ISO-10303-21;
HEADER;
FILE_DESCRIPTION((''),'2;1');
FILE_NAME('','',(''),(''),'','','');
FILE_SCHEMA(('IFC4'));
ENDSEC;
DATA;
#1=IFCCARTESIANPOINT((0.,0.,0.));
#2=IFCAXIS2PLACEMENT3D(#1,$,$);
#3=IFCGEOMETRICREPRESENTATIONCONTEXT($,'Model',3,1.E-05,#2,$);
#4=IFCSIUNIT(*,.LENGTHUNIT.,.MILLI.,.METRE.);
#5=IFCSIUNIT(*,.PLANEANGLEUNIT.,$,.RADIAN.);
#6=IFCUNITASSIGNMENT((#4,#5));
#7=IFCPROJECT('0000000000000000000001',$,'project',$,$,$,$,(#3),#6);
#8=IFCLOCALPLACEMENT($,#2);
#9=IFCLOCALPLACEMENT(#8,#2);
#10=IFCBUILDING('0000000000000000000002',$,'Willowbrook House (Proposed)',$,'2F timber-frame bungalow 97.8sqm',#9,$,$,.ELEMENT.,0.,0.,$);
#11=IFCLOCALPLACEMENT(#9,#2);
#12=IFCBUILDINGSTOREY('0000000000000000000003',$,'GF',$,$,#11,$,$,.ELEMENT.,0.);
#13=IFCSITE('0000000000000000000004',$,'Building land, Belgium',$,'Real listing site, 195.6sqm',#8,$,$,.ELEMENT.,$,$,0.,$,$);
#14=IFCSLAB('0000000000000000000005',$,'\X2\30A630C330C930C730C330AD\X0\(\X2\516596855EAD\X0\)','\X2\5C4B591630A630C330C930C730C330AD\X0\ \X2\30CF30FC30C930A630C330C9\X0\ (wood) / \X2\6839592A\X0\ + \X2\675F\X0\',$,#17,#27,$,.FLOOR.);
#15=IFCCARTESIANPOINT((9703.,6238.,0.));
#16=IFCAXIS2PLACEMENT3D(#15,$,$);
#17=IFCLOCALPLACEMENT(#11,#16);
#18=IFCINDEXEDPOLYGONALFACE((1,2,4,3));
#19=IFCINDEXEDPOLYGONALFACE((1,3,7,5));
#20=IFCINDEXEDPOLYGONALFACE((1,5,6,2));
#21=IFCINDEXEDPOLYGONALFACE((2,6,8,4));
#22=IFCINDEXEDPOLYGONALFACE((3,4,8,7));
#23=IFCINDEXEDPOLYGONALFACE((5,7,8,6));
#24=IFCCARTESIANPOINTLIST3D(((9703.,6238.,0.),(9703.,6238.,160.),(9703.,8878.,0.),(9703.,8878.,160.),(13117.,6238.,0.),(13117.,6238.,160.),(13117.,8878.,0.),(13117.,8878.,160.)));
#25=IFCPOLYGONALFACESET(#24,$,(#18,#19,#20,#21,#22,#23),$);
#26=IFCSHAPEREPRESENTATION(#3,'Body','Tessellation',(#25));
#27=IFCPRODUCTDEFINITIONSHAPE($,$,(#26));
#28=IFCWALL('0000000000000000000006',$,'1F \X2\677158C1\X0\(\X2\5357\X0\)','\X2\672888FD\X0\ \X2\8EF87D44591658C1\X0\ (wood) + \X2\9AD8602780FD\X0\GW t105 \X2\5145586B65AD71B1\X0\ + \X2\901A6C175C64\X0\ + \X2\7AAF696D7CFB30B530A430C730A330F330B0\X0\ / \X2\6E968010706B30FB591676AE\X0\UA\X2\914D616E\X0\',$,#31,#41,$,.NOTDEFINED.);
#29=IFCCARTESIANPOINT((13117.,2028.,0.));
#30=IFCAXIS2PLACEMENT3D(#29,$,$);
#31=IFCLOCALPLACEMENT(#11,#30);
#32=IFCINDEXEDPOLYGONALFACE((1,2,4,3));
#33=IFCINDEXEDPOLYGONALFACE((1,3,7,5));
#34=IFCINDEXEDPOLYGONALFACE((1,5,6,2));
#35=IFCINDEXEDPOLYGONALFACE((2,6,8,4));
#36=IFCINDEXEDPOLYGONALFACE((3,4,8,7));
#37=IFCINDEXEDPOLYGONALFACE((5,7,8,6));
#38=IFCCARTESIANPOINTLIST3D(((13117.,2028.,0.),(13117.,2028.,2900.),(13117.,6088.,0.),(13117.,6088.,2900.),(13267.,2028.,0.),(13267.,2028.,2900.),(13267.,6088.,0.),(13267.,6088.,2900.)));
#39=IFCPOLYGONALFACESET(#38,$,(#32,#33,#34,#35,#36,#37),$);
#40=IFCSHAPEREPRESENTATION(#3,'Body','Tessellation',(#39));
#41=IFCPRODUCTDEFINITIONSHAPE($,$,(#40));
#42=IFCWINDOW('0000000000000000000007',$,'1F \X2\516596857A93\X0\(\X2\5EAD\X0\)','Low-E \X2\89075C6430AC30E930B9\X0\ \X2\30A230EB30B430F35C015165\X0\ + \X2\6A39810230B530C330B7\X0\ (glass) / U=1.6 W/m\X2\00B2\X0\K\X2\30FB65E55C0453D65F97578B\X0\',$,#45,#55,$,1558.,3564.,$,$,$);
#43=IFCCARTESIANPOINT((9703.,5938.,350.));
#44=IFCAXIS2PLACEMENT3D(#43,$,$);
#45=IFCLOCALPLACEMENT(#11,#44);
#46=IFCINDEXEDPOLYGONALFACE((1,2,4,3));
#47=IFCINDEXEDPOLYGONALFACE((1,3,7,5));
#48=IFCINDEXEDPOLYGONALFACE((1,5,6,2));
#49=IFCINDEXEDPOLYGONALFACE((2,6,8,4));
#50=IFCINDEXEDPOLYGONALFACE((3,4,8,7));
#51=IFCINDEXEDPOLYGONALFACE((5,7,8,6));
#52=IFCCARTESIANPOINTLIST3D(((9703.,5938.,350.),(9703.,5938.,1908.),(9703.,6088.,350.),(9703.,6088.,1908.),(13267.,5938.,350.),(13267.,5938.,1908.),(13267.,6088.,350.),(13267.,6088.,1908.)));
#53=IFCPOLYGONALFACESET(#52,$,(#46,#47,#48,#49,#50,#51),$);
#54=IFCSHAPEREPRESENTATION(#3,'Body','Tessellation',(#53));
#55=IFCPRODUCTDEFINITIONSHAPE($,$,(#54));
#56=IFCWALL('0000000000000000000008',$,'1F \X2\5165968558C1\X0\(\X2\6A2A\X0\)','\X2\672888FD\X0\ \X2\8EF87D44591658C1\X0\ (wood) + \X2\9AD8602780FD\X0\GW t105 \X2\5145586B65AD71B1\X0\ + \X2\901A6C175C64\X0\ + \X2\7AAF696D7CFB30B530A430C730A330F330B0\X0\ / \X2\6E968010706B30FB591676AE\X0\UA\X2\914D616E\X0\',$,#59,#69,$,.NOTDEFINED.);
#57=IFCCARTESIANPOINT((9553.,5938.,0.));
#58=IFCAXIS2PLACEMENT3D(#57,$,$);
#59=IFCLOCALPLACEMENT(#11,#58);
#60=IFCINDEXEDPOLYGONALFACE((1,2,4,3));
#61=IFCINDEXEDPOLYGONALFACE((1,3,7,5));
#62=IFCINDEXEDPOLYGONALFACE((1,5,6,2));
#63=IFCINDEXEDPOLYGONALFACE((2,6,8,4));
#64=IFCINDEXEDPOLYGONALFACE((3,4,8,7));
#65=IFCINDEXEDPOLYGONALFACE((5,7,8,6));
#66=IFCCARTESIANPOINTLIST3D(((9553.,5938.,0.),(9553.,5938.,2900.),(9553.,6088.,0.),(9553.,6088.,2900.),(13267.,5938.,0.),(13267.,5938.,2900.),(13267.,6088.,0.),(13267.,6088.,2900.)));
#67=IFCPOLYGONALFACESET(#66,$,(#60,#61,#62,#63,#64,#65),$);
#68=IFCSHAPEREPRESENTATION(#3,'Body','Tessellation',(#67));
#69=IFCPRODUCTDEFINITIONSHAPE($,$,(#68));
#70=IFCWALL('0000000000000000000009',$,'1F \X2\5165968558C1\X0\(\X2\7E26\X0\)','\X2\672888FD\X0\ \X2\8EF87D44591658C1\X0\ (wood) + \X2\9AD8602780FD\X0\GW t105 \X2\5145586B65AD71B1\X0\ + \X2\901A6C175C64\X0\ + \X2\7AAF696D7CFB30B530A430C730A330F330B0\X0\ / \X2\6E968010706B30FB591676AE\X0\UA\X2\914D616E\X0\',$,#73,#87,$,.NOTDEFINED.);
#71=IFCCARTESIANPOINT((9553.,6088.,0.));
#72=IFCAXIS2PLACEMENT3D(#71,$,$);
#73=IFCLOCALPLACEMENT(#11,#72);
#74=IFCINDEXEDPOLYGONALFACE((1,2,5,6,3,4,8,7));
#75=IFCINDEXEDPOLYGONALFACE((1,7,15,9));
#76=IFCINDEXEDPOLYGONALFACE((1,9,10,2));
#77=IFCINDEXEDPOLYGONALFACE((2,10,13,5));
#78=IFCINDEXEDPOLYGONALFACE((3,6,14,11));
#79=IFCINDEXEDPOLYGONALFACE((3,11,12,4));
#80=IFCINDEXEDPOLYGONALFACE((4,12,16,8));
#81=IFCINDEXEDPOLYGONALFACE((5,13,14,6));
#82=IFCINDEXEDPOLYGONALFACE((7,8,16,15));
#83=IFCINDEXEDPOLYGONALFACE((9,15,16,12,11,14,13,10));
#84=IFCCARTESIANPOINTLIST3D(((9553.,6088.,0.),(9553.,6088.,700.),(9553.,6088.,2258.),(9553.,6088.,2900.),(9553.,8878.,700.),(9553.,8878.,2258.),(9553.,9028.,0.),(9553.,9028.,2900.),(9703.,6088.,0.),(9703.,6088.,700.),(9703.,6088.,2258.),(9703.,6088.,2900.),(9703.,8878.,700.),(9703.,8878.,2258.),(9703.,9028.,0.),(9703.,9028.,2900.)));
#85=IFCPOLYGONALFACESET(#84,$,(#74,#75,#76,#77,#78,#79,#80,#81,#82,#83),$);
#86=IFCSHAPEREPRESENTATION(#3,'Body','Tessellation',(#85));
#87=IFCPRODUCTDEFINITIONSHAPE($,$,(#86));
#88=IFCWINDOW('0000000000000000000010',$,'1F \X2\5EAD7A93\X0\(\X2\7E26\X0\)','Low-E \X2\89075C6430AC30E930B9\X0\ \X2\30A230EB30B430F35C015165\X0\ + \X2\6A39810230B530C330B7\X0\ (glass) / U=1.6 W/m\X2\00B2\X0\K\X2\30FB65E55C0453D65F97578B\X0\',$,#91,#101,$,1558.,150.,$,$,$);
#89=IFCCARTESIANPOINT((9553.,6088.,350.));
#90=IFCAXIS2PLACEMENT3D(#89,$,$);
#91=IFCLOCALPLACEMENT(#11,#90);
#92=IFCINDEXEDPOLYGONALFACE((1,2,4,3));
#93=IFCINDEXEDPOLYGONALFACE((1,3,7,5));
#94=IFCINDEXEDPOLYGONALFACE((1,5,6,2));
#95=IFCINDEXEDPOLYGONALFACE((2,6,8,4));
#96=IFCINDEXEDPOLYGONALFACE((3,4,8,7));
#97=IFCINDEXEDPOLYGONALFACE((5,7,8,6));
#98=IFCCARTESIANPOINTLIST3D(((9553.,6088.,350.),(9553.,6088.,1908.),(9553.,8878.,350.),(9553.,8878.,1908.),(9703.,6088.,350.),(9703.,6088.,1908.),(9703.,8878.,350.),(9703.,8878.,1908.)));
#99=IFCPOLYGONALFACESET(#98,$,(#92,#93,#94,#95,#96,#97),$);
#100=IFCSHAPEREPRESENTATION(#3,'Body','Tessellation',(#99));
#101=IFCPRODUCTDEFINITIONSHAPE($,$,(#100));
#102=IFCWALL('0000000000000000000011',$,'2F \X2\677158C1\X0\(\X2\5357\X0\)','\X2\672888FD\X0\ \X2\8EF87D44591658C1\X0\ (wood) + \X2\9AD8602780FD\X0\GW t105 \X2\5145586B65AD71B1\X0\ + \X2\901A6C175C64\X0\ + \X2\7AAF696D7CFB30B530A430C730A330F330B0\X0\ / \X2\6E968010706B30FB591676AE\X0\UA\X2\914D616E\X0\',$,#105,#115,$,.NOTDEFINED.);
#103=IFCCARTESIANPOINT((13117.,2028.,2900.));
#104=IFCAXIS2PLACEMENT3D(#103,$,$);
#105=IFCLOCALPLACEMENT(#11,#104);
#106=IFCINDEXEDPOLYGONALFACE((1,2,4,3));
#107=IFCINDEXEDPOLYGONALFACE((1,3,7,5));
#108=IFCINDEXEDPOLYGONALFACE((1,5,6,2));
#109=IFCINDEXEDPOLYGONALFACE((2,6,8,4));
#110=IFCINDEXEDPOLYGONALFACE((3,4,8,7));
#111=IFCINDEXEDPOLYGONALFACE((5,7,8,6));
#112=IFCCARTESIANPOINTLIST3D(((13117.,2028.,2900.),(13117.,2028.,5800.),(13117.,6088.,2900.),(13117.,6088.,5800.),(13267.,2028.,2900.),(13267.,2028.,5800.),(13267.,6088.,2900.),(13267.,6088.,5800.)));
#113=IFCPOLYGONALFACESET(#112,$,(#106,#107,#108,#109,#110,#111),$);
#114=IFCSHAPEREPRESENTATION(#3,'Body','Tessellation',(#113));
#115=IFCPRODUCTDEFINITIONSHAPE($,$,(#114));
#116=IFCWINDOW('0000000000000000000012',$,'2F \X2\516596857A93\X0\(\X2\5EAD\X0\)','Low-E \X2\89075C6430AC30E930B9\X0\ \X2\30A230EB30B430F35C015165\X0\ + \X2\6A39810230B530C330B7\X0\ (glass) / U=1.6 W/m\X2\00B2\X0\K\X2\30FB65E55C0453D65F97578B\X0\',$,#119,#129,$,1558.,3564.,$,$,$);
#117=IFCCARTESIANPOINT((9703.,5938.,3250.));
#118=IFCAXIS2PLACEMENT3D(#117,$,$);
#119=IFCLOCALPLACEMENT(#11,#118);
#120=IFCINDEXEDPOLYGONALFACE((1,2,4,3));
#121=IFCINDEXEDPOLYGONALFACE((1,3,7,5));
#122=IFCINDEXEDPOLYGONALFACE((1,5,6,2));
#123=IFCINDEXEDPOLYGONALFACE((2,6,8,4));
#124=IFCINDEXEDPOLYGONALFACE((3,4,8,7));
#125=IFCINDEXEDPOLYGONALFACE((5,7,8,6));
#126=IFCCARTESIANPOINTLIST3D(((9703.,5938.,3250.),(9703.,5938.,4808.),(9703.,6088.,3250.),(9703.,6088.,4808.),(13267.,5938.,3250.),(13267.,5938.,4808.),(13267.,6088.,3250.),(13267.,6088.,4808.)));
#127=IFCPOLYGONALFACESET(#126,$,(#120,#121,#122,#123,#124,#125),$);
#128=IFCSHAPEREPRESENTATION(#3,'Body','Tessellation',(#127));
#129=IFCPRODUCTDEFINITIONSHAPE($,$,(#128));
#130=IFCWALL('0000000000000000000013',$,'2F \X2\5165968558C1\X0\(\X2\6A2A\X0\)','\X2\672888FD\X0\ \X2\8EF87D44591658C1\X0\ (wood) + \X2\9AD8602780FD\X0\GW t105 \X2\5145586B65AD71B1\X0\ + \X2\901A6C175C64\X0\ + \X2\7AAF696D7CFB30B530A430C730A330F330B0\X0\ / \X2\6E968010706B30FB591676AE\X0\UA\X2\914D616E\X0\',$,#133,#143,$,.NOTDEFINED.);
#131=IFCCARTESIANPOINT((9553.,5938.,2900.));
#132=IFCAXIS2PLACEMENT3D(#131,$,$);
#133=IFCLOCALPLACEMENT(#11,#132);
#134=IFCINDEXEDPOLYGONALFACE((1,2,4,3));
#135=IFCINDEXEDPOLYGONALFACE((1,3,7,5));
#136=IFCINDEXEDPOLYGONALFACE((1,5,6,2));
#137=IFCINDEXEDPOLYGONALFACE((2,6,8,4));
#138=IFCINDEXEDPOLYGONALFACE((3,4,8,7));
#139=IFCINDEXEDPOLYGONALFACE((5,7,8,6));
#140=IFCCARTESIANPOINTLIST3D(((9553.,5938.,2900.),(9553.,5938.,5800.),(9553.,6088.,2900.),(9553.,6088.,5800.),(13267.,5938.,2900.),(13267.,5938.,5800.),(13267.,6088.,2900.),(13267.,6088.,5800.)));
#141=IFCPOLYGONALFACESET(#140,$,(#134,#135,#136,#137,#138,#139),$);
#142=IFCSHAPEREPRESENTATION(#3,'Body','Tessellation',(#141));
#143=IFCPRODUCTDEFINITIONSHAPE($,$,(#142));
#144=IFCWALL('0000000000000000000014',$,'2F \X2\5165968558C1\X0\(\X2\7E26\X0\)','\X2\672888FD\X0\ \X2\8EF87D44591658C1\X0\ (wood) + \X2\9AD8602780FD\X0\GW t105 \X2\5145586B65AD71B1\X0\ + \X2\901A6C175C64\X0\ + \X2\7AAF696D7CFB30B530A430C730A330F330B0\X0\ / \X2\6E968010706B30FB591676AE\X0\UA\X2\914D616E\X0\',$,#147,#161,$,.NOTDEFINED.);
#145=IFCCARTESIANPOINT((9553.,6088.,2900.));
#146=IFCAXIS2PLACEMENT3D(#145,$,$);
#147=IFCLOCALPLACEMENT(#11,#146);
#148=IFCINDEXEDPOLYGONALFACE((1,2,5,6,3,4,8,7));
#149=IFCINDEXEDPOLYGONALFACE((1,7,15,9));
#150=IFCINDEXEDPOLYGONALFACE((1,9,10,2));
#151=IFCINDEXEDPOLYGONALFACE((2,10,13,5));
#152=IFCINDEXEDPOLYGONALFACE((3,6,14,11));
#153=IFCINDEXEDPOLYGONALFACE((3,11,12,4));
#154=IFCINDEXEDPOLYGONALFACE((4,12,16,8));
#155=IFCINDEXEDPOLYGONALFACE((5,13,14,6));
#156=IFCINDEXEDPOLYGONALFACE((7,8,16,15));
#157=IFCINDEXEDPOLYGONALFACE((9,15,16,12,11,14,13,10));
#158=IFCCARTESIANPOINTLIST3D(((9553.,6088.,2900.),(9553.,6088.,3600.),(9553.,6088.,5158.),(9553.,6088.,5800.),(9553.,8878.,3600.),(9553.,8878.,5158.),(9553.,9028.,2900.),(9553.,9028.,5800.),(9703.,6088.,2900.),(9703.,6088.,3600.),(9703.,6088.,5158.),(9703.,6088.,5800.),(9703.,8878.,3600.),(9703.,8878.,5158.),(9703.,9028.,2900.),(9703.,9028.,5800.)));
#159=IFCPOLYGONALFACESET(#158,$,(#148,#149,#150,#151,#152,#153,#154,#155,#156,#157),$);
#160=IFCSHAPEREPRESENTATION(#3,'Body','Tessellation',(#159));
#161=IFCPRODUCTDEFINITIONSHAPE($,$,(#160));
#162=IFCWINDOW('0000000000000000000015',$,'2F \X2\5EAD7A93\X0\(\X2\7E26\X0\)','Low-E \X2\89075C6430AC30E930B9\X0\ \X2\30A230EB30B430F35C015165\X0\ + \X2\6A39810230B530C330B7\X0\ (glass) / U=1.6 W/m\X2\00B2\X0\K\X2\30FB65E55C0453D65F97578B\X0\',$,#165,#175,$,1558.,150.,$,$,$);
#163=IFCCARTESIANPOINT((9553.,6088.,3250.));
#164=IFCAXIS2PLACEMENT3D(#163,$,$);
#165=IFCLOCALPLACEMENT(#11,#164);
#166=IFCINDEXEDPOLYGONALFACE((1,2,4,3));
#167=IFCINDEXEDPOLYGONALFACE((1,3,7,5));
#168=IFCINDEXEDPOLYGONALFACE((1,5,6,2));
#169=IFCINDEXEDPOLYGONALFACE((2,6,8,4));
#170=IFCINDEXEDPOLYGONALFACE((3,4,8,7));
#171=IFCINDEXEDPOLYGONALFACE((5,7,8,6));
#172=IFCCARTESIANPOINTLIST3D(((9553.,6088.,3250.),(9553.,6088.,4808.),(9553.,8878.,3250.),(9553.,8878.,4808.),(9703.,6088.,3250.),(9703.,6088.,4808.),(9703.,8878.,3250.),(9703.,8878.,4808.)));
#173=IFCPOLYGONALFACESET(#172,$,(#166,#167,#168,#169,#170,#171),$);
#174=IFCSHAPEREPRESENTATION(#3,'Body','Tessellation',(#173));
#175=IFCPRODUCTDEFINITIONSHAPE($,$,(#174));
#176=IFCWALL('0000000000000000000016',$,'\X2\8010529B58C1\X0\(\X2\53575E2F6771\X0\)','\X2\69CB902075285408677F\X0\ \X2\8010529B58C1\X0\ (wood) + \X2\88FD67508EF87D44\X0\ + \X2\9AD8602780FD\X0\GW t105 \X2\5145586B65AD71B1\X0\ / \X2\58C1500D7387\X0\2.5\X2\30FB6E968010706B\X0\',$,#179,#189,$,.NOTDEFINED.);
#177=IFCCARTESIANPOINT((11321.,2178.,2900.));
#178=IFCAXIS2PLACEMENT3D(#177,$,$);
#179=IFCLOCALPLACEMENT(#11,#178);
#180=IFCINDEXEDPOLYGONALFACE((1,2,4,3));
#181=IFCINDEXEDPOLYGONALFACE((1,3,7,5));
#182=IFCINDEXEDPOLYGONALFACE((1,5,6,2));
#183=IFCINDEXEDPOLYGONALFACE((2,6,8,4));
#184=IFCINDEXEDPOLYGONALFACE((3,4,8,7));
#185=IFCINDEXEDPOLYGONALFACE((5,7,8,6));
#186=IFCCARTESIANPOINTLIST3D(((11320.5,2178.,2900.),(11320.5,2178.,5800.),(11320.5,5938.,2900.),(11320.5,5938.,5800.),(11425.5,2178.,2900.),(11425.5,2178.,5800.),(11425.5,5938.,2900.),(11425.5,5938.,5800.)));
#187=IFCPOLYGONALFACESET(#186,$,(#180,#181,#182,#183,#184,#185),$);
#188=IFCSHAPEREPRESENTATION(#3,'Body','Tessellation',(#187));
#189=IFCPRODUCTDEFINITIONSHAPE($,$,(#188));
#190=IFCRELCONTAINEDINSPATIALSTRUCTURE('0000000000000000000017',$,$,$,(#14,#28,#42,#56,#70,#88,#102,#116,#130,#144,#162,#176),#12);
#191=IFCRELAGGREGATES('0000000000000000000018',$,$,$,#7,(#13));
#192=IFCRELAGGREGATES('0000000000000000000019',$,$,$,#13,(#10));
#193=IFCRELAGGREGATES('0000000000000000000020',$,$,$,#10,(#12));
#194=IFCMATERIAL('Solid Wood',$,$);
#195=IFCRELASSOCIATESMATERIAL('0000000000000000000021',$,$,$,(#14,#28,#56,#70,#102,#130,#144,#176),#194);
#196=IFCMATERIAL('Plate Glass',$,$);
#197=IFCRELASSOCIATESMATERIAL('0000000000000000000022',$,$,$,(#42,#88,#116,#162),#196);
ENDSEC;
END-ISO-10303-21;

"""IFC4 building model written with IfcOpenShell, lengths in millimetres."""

from ifc_helpers import new_model, si_unit, frame, frame_2d, origin, place, context, project, spatial, rectangle, extrude, material, element, fill, save


model = new_model("IFC4")

# Units and contexts
model_context = context("Model", 3, precision=1e-05, world=origin())
ifc_project = project(units=[si_unit("LENGTHUNIT", "METRE", prefix="MILLI"), si_unit("PLANEANGLEUNIT", "RADIAN")], contexts=[model_context])

# Site, building, storey
site_placement = place(None, origin())
site = spatial("IfcSite", under=ifc_project, at=site_placement, Name="Building land, Belgium", ObjectType="Real listing site, 195.6sqm", CompositionType="ELEMENT", RefElevation=0.0)
building_placement = place(site_placement, origin())
building = spatial("IfcBuilding", under=site, at=building_placement, Name="Willowbrook House (Proposed)", ObjectType="2F timber-frame bungalow 97.8sqm", CompositionType="ELEMENT", ElevationOfRefHeight=0.0, ElevationOfTerrain=0.0)
storey_placement = place(building_placement, origin())
storey = spatial("IfcBuildingStorey", under=building, at=storey_placement, Name="GF", CompositionType="ELEMENT", Elevation=0.0)

# Slab
ifc_material_1 = material(Name="Solid Wood")
slab_placement = place(storey_placement, frame((9703.0, 6238.0, 0.0)))
element("IfcSlab", 1, at=slab_placement, inside=storey, material=ifc_material_1, Name="ウッドデッキ(入隅庭)", Description="屋外ウッドデッキ ハードウッド (wood) / 根太 + 束", PredefinedType="FLOOR", context=model_context, shape_type="SweptSolid", body=[
    extrude(rectangle(XDim=3414.0, YDim=2640.0, at=frame_2d((1707.0, 1320.0))), frame((9703.0, 6238.0, 0.0)), (0.0, 0.0, 1.0), 160.0),
])

# Wall, opening, window
wall_1_placement = place(storey_placement, frame((13117.0, 2028.0, 0.0)))
wall_1 = element("IfcWall", 2, at=wall_1_placement, inside=storey, material=ifc_material_1, Name="1F 東壁(南)", Description="木製 軸組外壁 (wood) + 高性能GW t105 充填断熱 + 通気層 + 窯業系サイディング / 準耐火・外皮UA配慮", PredefinedType="NOTDEFINED", context=model_context, shape_type="SweptSolid", body=[
    extrude(rectangle(XDim=150.0, YDim=4060.0, at=frame_2d((75.0, 2030.0))), frame((13117.0, 2028.0, 0.0)), (0.0, 0.0, 1.0), 2900.0),
])
opening_1_placement = place(storey_placement, frame((9703.0, 5938.0, 350.0)))
opening_1 = element("IfcOpeningElement", 3, at=opening_1_placement, cuts=wall_1, PredefinedType="NOTDEFINED", context=model_context, shape_type="SweptSolid", body=[
    extrude(rectangle(XDim=3564.0, YDim=150.0, at=frame_2d((1782.0, 75.0))), frame((9703.0, 5938.0, 350.0)), (0.0, 0.0, 1.0), 1558.0),
])
ifc_material_2 = material(Name="Plate Glass")
window_1_placement = place(storey_placement, frame((9703.0, 5938.0, 350.0)))
window_1 = element("IfcWindow", 4, at=window_1_placement, inside=storey, material=ifc_material_2, Name="1F 入隅窓(庭)", Description="Low-E 複層ガラス アルゴン封入 + 樹脂サッシ (glass) / U=1.6 W/m²K・日射取得型", OverallHeight=1558.0, OverallWidth=3564.0, context=model_context, shape_type="SweptSolid", body=[
    extrude(rectangle(XDim=3564.0, YDim=150.0, at=frame_2d((1782.0, 75.0))), frame((9703.0, 5938.0, 350.0)), (0.0, 0.0, 1.0), 1558.0),
])
fill(opening_1, window_1)

# Wall
wall_2_placement = place(storey_placement, frame((9553.0, 5938.0, 0.0)))
element("IfcWall", 5, at=wall_2_placement, inside=storey, material=ifc_material_1, Name="1F 入隅壁(横)", Description="木製 軸組外壁 (wood) + 高性能GW t105 充填断熱 + 通気層 + 窯業系サイディング / 準耐火・外皮UA配慮", PredefinedType="NOTDEFINED", context=model_context, shape_type="SweptSolid", body=[
    extrude(rectangle(XDim=3714.0, YDim=150.0, at=frame_2d((1857.0, 75.0))), frame((9553.0, 5938.0, 0.0)), (0.0, 0.0, 1.0), 2900.0),
])

# Wall, opening, window
wall_3_placement = place(storey_placement, frame((9553.0, 6088.0, 0.0)))
wall_3 = element("IfcWall", 6, at=wall_3_placement, inside=storey, material=ifc_material_1, Name="1F 入隅壁(縦)", Description="木製 軸組外壁 (wood) + 高性能GW t105 充填断熱 + 通気層 + 窯業系サイディング / 準耐火・外皮UA配慮", PredefinedType="NOTDEFINED", context=model_context, shape_type="SweptSolid", body=[
    extrude(rectangle(XDim=150.0, YDim=2940.0, at=frame_2d((75.0, 1470.0))), frame((9553.0, 6088.0, 0.0)), (0.0, 0.0, 1.0), 2900.0),
])
opening_2_placement = place(storey_placement, frame((9553.0, 6088.0, 350.0)))
opening_2 = element("IfcOpeningElement", 7, at=opening_2_placement, cuts=wall_3, PredefinedType="NOTDEFINED", context=model_context, shape_type="SweptSolid", body=[
    extrude(rectangle(XDim=150.0, YDim=2790.0, at=frame_2d((75.0, 1395.0))), frame((9553.0, 6088.0, 350.0)), (0.0, 0.0, 1.0), 1558.0),
])
window_2_placement = place(storey_placement, frame((9553.0, 6088.0, 350.0)))
window_2 = element("IfcWindow", 8, at=window_2_placement, inside=storey, material=ifc_material_2, Name="1F 庭窓(縦)", Description="Low-E 複層ガラス アルゴン封入 + 樹脂サッシ (glass) / U=1.6 W/m²K・日射取得型", OverallHeight=1558.0, OverallWidth=150.0, context=model_context, shape_type="SweptSolid", body=[
    extrude(rectangle(XDim=150.0, YDim=2790.0, at=frame_2d((75.0, 1395.0))), frame((9553.0, 6088.0, 350.0)), (0.0, 0.0, 1.0), 1558.0),
])
fill(opening_2, window_2)

# Wall, opening, window
wall_4_placement = place(storey_placement, frame((13117.0, 2028.0, 2900.0)))
wall_4 = element("IfcWall", 9, at=wall_4_placement, inside=storey, material=ifc_material_1, Name="2F 東壁(南)", Description="木製 軸組外壁 (wood) + 高性能GW t105 充填断熱 + 通気層 + 窯業系サイディング / 準耐火・外皮UA配慮", PredefinedType="NOTDEFINED", context=model_context, shape_type="SweptSolid", body=[
    extrude(rectangle(XDim=150.0, YDim=4060.0, at=frame_2d((75.0, 2030.0))), frame((13117.0, 2028.0, 2900.0)), (0.0, 0.0, 1.0), 2900.0),
])
opening_3_placement = place(storey_placement, frame((9703.0, 5938.0, 3250.0)))
opening_3 = element("IfcOpeningElement", 10, at=opening_3_placement, cuts=wall_4, PredefinedType="NOTDEFINED", context=model_context, shape_type="SweptSolid", body=[
    extrude(rectangle(XDim=3564.0, YDim=150.0, at=frame_2d((1782.0, 75.0))), frame((9703.0, 5938.0, 3250.0)), (0.0, 0.0, 1.0), 1558.0),
])
window_3_placement = place(storey_placement, frame((9703.0, 5938.0, 3250.0)))
window_3 = element("IfcWindow", 11, at=window_3_placement, inside=storey, material=ifc_material_2, Name="2F 入隅窓(庭)", Description="Low-E 複層ガラス アルゴン封入 + 樹脂サッシ (glass) / U=1.6 W/m²K・日射取得型", OverallHeight=1558.0, OverallWidth=3564.0, context=model_context, shape_type="SweptSolid", body=[
    extrude(rectangle(XDim=3564.0, YDim=150.0, at=frame_2d((1782.0, 75.0))), frame((9703.0, 5938.0, 3250.0)), (0.0, 0.0, 1.0), 1558.0),
])
fill(opening_3, window_3)

# Wall
wall_5_placement = place(storey_placement, frame((9553.0, 5938.0, 2900.0)))
element("IfcWall", 12, at=wall_5_placement, inside=storey, material=ifc_material_1, Name="2F 入隅壁(横)", Description="木製 軸組外壁 (wood) + 高性能GW t105 充填断熱 + 通気層 + 窯業系サイディング / 準耐火・外皮UA配慮", PredefinedType="NOTDEFINED", context=model_context, shape_type="SweptSolid", body=[
    extrude(rectangle(XDim=3714.0, YDim=150.0, at=frame_2d((1857.0, 75.0))), frame((9553.0, 5938.0, 2900.0)), (0.0, 0.0, 1.0), 2900.0),
])

# Wall, opening, window
wall_6_placement = place(storey_placement, frame((9553.0, 6088.0, 2900.0)))
wall_6 = element("IfcWall", 13, at=wall_6_placement, inside=storey, material=ifc_material_1, Name="2F 入隅壁(縦)", Description="木製 軸組外壁 (wood) + 高性能GW t105 充填断熱 + 通気層 + 窯業系サイディング / 準耐火・外皮UA配慮", PredefinedType="NOTDEFINED", context=model_context, shape_type="SweptSolid", body=[
    extrude(rectangle(XDim=150.0, YDim=2940.0, at=frame_2d((75.0, 1470.0))), frame((9553.0, 6088.0, 2900.0)), (0.0, 0.0, 1.0), 2900.0),
])
opening_4_placement = place(storey_placement, frame((9553.0, 6088.0, 3250.0)))
opening_4 = element("IfcOpeningElement", 14, at=opening_4_placement, cuts=wall_6, PredefinedType="NOTDEFINED", context=model_context, shape_type="SweptSolid", body=[
    extrude(rectangle(XDim=150.0, YDim=2790.0, at=frame_2d((75.0, 1395.0))), frame((9553.0, 6088.0, 3250.0)), (0.0, 0.0, 1.0), 1558.0),
])
window_4_placement = place(storey_placement, frame((9553.0, 6088.0, 3250.0)))
window_4 = element("IfcWindow", 15, at=window_4_placement, inside=storey, material=ifc_material_2, Name="2F 庭窓(縦)", Description="Low-E 複層ガラス アルゴン封入 + 樹脂サッシ (glass) / U=1.6 W/m²K・日射取得型", OverallHeight=1558.0, OverallWidth=150.0, context=model_context, shape_type="SweptSolid", body=[
    extrude(rectangle(XDim=150.0, YDim=2790.0, at=frame_2d((75.0, 1395.0))), frame((9553.0, 6088.0, 3250.0)), (0.0, 0.0, 1.0), 1558.0),
])
fill(opening_4, window_4)

# Wall
wall_7_placement = place(storey_placement, frame((11321.0, 2178.0, 2900.0)))
element("IfcWall", 16, at=wall_7_placement, inside=storey, material=ifc_material_1, Name="耐力壁(南帯東)", Description="構造用合板 耐力壁 (wood) + 製材軸組 + 高性能GW t105 充填断熱 / 壁倍率2.5・準耐火", PredefinedType="NOTDEFINED", context=model_context, shape_type="SweptSolid", body=[
    extrude(rectangle(XDim=105.0, YDim=3760.0, at=frame_2d((52.0, 1880.0))), frame((11321.0, 2178.0, 2900.0)), (0.0, 0.0, 1.0), 2900.0),
])

save(model, "model.ifc")
